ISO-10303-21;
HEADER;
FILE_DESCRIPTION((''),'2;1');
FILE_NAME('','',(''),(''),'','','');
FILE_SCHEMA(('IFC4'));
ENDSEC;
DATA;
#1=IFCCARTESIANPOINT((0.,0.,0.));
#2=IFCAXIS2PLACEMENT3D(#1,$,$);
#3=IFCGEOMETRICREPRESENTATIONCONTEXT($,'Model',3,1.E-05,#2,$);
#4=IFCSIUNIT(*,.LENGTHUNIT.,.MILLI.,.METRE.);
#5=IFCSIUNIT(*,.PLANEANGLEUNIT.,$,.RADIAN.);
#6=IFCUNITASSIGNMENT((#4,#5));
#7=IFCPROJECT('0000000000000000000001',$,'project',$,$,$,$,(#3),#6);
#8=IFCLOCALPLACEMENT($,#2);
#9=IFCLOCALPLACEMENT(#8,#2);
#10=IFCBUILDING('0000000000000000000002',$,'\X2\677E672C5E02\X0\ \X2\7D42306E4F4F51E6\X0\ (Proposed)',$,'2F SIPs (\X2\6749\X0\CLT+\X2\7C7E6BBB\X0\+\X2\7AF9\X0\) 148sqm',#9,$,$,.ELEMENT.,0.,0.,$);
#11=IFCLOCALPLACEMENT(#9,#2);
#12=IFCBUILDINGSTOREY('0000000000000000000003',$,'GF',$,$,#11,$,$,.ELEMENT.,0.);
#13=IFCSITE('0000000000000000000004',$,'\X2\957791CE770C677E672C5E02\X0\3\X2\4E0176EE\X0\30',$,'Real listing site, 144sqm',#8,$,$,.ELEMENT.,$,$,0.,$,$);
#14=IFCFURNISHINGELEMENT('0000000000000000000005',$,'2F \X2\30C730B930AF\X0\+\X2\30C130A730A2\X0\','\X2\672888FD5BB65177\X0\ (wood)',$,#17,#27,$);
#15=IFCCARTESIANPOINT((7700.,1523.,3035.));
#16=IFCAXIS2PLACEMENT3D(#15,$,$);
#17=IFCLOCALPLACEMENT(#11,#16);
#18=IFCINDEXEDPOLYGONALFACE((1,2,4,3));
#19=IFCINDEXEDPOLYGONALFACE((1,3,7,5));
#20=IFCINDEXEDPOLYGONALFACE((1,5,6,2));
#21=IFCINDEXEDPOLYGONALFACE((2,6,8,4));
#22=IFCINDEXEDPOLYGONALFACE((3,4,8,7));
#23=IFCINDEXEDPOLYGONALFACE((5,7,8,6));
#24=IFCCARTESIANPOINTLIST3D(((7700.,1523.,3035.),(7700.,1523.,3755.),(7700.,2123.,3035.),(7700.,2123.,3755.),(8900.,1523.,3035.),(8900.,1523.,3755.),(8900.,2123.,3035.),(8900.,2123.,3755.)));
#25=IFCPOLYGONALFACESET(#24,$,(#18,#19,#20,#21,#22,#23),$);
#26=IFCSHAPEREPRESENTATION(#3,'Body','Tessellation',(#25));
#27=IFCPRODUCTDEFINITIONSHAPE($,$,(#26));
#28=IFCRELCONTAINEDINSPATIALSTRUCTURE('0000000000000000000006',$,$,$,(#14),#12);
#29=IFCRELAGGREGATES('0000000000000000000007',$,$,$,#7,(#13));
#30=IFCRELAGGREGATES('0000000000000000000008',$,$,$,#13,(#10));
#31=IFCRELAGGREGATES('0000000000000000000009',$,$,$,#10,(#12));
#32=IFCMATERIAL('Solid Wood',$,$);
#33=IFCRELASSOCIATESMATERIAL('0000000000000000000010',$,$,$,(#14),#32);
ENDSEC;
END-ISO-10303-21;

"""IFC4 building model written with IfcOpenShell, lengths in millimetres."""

from ifc_helpers import new_model, si_unit, frame, frame_2d, origin, place, context, project, spatial, rectangle, extrude, material, element, save


model = new_model("IFC4")

# Units and contexts
model_context = context("Model", 3, precision=1e-05, world=origin())
ifc_project = project(units=[si_unit("LENGTHUNIT", "METRE", prefix="MILLI"), si_unit("PLANEANGLEUNIT", "RADIAN")], contexts=[model_context])

# Site, building, storey
site_placement = place(None, origin())
site = spatial("IfcSite", under=ifc_project, at=site_placement, Name="長野県松本市3丁目30", ObjectType="Real listing site, 144sqm", CompositionType="ELEMENT", RefElevation=0.0)
building_placement = place(site_placement, origin())
building = spatial("IfcBuilding", under=site, at=building_placement, Name="松本市 終の住処 (Proposed)", ObjectType="2F SIPs (杉CLT+籾殻+竹) 148sqm", CompositionType="ELEMENT", ElevationOfRefHeight=0.0, ElevationOfTerrain=0.0)
storey_placement = place(building_placement, origin())
storey = spatial("IfcBuildingStorey", under=building, at=storey_placement, Name="GF", CompositionType="ELEMENT", Elevation=0.0)

# Shared definitions
ifc_material_1 = material(Name="Solid Wood")

# Furnishing element
furnishing_1_placement = place(storey_placement, frame((7700.0, 1523.0, 3035.0)))
element("IfcFurnishingElement", 1, at=furnishing_1_placement, inside=storey, material=ifc_material_1, Name="2F デスク+チェア", Description="木製家具 (wood)", context=model_context, shape_type="SweptSolid", body=[
    extrude(rectangle(XDim=1200.0, YDim=600.0, at=frame_2d((600.0, 300.0))), frame((7700.0, 1523.0, 3035.0)), (0.0, 0.0, 1.0), 720.0),
])

save(model, "model.ifc")
